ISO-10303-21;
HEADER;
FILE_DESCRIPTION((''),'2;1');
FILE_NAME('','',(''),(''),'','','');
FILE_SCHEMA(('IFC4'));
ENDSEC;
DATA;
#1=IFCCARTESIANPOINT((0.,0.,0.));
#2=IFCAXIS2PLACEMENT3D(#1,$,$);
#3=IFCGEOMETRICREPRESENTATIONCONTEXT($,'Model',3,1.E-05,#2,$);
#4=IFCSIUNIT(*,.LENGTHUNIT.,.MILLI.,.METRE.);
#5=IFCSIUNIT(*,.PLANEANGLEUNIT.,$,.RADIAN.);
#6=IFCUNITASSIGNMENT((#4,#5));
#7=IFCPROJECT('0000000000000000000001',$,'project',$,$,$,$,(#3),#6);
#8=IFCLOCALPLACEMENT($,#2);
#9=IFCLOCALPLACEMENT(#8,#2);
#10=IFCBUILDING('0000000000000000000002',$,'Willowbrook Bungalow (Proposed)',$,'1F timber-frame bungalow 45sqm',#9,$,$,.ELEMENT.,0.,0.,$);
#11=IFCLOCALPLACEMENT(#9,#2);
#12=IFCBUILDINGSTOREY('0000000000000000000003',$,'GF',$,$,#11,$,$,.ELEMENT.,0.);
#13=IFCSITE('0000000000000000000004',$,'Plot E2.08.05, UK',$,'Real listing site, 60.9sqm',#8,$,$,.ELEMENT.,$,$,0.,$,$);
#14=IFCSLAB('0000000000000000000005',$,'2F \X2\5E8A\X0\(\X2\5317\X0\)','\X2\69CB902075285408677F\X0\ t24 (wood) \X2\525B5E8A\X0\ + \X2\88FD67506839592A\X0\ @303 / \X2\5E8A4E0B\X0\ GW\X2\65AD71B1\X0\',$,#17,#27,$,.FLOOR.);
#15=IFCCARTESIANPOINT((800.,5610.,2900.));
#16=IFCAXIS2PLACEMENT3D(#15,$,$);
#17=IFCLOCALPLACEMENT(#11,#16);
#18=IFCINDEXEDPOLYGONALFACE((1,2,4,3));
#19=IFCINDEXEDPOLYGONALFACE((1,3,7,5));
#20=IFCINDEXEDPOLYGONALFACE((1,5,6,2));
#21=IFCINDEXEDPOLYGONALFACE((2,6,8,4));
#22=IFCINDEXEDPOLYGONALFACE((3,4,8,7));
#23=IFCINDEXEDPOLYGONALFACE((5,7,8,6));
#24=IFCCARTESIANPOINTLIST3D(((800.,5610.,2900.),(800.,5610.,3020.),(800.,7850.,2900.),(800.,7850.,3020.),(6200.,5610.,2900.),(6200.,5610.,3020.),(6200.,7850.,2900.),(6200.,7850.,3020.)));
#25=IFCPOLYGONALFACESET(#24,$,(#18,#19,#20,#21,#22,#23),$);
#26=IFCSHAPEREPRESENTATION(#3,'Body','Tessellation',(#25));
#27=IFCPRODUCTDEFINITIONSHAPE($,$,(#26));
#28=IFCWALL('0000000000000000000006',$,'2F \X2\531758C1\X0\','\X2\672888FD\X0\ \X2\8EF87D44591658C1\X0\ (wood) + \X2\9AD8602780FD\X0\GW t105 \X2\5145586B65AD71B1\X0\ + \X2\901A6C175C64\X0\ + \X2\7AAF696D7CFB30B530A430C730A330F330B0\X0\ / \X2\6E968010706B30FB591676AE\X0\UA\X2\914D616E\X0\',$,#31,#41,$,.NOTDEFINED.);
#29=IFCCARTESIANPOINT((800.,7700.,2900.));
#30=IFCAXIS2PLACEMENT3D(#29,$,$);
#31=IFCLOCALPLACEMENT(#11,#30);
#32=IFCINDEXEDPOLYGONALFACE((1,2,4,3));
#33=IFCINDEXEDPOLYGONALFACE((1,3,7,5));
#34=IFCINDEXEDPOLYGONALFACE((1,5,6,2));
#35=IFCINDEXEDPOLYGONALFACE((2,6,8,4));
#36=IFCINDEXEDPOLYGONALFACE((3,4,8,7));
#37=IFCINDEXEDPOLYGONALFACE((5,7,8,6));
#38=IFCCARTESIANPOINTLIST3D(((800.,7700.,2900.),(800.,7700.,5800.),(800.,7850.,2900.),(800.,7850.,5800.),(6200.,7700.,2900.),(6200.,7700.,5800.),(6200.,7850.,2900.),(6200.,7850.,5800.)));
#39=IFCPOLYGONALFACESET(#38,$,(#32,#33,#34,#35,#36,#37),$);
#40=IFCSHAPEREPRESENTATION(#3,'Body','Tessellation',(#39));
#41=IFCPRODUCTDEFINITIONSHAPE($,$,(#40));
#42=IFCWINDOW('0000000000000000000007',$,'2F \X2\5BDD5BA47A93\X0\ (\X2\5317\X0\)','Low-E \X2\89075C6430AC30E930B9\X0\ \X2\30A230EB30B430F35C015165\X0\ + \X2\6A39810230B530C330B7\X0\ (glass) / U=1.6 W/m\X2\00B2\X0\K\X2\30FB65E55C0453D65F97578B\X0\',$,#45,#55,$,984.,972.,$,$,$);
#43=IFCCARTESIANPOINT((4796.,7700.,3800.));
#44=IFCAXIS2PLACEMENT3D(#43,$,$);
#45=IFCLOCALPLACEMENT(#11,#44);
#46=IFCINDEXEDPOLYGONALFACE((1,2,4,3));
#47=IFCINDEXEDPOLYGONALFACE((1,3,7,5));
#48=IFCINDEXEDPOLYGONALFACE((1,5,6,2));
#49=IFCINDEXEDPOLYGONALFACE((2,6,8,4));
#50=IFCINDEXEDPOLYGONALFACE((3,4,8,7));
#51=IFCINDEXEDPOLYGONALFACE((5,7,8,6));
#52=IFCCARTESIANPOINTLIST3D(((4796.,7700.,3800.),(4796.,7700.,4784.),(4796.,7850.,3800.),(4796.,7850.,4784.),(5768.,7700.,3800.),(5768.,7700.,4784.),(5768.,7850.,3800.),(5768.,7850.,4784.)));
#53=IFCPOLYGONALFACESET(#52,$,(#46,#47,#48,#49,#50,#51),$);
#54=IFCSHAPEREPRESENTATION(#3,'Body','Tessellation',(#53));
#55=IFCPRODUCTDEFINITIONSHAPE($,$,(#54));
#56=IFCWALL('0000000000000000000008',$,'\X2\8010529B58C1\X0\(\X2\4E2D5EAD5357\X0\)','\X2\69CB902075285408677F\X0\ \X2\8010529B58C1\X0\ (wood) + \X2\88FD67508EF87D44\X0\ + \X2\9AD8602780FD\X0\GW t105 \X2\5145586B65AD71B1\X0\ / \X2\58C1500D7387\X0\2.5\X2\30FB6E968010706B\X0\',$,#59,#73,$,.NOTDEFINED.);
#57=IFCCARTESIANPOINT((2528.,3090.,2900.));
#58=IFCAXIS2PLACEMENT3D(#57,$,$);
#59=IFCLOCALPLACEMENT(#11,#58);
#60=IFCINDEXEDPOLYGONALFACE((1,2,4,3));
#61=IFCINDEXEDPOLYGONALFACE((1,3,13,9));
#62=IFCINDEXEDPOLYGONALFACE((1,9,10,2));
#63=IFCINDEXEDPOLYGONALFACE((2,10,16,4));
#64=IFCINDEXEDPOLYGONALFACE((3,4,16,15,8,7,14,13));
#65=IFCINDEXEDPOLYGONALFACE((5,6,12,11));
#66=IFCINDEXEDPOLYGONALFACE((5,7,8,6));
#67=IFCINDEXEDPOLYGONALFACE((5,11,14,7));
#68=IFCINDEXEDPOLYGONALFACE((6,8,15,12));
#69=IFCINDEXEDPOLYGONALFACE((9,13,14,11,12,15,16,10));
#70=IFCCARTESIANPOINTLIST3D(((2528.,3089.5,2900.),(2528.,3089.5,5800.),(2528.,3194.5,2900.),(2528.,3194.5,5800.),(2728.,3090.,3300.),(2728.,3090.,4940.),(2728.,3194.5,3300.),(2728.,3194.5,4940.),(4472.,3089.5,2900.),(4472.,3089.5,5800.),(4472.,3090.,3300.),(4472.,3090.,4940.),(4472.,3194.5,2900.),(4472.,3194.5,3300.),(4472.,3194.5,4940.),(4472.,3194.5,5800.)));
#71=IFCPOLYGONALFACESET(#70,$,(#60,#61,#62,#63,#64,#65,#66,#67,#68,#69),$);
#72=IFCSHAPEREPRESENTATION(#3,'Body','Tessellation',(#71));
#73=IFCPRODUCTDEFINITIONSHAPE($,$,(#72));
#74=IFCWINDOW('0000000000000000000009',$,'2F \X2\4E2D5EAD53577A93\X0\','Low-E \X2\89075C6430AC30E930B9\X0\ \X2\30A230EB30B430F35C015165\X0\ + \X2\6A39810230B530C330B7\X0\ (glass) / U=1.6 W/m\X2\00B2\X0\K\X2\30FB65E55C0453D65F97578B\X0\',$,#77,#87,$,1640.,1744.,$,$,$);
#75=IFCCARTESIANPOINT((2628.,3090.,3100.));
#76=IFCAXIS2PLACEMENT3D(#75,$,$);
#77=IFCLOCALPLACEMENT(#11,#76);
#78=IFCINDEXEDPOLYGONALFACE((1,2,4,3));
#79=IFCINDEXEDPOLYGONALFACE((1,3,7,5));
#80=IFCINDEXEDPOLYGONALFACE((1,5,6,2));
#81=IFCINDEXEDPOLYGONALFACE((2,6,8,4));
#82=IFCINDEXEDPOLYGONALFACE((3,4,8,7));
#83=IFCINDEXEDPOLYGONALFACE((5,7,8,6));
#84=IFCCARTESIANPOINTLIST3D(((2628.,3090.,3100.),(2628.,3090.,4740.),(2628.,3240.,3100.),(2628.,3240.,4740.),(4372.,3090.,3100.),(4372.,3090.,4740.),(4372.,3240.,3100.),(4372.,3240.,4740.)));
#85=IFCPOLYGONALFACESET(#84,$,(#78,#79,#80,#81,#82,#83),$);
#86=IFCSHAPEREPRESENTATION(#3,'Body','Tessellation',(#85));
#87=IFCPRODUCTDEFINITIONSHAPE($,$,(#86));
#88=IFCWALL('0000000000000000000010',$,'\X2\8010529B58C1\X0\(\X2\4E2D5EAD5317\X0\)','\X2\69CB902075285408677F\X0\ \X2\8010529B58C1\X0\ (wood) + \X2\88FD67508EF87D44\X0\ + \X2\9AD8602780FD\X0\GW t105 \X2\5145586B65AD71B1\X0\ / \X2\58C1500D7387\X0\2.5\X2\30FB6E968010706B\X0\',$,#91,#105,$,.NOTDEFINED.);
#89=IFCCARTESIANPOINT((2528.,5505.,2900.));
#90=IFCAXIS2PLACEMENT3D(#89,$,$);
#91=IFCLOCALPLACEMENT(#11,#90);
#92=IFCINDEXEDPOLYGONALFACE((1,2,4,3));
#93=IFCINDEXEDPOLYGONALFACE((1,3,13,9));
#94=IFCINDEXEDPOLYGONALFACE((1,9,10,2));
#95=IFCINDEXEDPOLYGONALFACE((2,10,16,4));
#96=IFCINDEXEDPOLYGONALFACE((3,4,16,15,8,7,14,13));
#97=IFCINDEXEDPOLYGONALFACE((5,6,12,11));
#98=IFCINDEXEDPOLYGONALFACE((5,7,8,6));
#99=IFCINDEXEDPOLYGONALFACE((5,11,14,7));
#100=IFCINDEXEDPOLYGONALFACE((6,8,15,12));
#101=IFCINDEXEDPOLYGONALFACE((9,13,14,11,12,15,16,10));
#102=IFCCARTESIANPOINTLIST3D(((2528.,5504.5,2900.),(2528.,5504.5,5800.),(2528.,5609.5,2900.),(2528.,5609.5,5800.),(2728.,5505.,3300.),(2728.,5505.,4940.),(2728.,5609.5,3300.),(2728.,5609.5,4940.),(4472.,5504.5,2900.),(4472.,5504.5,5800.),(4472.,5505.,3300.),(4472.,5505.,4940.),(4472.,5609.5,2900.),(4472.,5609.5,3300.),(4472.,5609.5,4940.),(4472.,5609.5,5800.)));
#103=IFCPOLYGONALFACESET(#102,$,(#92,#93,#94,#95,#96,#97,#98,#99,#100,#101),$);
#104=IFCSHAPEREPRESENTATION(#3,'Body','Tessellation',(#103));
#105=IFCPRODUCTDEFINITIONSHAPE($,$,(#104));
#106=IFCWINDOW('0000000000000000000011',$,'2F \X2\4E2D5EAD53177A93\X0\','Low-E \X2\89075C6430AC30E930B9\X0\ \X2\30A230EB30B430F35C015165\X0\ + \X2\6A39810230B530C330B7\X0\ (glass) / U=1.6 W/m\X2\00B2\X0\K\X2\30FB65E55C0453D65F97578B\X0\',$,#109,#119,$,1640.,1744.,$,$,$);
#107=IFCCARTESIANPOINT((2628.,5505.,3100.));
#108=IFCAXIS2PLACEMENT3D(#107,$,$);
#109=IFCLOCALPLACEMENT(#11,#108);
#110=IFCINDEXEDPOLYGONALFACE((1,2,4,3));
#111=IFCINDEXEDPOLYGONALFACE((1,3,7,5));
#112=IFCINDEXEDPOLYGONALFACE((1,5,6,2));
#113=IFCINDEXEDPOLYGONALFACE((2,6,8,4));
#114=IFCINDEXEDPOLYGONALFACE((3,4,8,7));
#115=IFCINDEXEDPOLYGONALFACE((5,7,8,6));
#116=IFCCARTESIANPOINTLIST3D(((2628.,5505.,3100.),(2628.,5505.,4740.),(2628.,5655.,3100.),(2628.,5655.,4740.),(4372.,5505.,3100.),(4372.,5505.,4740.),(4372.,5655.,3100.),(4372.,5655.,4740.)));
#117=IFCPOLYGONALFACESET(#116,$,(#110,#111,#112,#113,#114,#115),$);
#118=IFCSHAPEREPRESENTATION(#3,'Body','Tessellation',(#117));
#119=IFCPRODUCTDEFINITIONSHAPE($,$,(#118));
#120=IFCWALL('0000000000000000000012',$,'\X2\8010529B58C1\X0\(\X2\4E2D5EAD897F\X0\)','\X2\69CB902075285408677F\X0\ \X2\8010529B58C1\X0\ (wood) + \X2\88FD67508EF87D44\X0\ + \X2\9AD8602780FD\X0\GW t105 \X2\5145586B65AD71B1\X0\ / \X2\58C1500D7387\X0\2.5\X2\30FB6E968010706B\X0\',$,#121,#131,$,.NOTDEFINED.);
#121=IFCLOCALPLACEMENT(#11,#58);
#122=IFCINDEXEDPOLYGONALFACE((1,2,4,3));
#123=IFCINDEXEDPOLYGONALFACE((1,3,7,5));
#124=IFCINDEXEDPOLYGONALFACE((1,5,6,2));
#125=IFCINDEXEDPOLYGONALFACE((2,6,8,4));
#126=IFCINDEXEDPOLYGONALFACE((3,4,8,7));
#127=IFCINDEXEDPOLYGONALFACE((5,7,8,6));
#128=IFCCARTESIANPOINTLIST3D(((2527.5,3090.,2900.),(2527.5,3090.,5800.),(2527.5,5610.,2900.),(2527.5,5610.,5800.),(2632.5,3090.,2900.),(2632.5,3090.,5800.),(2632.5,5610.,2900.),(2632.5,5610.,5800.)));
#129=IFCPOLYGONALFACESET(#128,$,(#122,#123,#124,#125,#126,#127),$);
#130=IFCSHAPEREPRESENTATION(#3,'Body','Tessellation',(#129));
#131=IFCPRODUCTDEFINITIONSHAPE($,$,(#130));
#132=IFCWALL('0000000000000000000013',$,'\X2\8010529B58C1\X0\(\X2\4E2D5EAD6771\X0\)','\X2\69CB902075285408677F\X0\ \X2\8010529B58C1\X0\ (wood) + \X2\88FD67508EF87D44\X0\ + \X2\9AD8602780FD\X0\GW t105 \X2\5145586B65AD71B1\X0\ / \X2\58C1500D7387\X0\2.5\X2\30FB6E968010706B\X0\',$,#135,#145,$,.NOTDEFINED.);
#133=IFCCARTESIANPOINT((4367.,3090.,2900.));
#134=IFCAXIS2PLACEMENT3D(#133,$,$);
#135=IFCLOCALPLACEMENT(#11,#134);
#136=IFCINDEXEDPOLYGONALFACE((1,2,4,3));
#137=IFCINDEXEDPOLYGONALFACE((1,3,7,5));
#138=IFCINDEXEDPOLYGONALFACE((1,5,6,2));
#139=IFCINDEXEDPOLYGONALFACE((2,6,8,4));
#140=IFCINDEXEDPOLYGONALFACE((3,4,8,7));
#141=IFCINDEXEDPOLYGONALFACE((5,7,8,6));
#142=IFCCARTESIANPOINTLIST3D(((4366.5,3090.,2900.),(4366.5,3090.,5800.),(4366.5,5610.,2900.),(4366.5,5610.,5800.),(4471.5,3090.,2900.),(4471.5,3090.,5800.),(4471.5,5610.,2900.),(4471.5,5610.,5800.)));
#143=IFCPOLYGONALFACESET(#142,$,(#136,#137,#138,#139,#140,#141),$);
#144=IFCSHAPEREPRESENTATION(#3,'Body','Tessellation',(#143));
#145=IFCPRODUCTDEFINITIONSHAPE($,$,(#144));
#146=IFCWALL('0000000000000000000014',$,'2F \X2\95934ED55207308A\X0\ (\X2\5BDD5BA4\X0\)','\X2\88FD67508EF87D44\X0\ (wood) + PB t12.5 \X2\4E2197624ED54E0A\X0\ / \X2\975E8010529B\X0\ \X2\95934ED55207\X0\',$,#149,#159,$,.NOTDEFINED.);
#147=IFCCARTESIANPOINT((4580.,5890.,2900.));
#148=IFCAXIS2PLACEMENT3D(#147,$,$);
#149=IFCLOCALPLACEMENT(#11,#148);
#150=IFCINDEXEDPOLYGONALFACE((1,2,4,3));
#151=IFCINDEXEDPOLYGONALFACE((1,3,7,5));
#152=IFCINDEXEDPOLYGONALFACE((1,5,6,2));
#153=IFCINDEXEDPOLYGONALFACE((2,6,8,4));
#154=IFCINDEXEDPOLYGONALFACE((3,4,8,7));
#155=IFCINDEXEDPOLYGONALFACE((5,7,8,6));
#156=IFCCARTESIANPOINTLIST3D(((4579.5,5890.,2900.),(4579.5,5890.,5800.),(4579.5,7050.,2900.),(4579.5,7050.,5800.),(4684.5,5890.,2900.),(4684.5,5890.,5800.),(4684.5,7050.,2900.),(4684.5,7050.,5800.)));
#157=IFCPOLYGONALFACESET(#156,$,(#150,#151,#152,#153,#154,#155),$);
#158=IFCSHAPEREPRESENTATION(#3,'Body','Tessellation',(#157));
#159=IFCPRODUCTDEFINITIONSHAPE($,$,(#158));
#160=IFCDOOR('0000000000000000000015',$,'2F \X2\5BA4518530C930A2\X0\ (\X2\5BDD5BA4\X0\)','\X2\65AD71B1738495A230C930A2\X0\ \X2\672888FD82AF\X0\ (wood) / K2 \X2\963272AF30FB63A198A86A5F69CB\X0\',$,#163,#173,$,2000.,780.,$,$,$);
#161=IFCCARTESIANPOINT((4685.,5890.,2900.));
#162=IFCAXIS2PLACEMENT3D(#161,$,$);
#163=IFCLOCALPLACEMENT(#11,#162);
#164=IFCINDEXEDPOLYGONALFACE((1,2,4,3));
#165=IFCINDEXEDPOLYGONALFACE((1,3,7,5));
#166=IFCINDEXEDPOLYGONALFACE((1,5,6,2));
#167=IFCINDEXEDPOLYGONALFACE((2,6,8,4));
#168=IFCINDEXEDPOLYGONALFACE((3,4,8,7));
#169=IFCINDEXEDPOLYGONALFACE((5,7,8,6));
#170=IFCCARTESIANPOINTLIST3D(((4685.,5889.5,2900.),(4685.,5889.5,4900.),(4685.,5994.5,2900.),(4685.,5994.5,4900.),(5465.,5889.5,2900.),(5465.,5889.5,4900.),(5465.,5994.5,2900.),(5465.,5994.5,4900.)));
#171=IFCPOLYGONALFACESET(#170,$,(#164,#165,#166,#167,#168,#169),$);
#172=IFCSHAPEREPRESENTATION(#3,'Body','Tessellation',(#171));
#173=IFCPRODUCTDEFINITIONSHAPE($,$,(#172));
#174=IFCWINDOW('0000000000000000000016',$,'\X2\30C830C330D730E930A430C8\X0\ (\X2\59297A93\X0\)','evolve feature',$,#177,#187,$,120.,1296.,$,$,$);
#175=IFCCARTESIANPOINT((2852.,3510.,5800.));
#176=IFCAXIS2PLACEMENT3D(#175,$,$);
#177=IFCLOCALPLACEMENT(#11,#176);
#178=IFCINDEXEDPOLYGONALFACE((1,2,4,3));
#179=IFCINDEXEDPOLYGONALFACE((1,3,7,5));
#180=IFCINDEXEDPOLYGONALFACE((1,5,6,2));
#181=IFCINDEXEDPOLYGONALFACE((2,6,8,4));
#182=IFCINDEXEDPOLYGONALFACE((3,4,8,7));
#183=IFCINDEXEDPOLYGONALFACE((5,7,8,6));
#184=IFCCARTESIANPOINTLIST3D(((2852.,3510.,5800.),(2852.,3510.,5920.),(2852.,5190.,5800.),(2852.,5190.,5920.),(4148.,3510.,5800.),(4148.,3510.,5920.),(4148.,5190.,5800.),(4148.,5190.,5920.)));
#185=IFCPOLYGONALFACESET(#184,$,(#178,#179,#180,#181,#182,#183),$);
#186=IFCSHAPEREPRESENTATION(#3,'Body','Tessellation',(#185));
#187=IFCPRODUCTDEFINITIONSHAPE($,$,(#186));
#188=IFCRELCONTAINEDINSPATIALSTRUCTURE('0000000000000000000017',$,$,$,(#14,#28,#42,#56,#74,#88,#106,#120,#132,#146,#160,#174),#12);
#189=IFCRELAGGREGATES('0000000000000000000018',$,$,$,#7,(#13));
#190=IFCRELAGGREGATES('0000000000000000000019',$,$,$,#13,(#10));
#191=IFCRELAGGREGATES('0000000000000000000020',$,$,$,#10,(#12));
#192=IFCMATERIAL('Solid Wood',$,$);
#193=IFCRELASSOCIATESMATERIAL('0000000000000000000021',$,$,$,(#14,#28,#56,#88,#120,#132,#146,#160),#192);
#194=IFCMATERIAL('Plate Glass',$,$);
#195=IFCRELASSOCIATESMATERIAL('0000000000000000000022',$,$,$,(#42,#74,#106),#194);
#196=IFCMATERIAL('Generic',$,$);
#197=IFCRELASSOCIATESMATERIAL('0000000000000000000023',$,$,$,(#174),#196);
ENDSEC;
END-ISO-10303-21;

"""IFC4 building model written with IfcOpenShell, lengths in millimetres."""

from ifc_helpers import new_model, si_unit, frame, frame_2d, origin, place, context, project, spatial, rectangle, extrude, material, element, fill, save


model = new_model("IFC4")

# Units and contexts
model_context = context("Model", 3, precision=1e-05, world=origin())
ifc_project = project(units=[si_unit("LENGTHUNIT", "METRE", prefix="MILLI"), si_unit("PLANEANGLEUNIT", "RADIAN")], contexts=[model_context])

# Site, building, storey
site_placement = place(None, origin())
site = spatial("IfcSite", under=ifc_project, at=site_placement, Name="Plot E2.08.05, UK", ObjectType="Real listing site, 60.9sqm", CompositionType="ELEMENT", RefElevation=0.0)
building_placement = place(site_placement, origin())
building = spatial("IfcBuilding", under=site, at=building_placement, Name="Willowbrook Bungalow (Proposed)", ObjectType="1F timber-frame bungalow 45sqm", CompositionType="ELEMENT", ElevationOfRefHeight=0.0, ElevationOfTerrain=0.0)
storey_placement = place(building_placement, origin())
storey = spatial("IfcBuildingStorey", under=building, at=storey_placement, Name="GF", CompositionType="ELEMENT", Elevation=0.0)

# Slab
ifc_material_1 = material(Name="Solid Wood")
slab_placement = place(storey_placement, frame((800.0, 5610.0, 2900.0)))
element("IfcSlab", 1, at=slab_placement, inside=storey, material=ifc_material_1, Name="2F 床(北)", Description="構造用合板 t24 (wood) 剛床 + 製材根太 @303 / 床下 GW断熱", PredefinedType="FLOOR", context=model_context, shape_type="SweptSolid", body=[
    extrude(rectangle(XDim=5400.0, YDim=2240.0, at=frame_2d((2700.0, 1120.0))), frame((800.0, 5610.0, 2900.0)), (0.0, 0.0, 1.0), 120.0),
])

# Walls, openings, windows
wall_1_placement = place(storey_placement, frame((800.0, 7700.0, 2900.0)))
wall_1 = element("IfcWall", 2, at=wall_1_placement, inside=storey, material=ifc_material_1, Name="2F 北壁", Description="木製 軸組外壁 (wood) + 高性能GW t105 充填断熱 + 通気層 + 窯業系サイディング / 準耐火・外皮UA配慮", PredefinedType="NOTDEFINED", context=model_context, shape_type="SweptSolid", body=[
    extrude(rectangle(XDim=5400.0, YDim=150.0, at=frame_2d((2700.0, 75.0))), frame((800.0, 7700.0, 2900.0)), (0.0, 0.0, 1.0), 2900.0),
])
opening_1_placement = place(storey_placement, frame((4796.0, 7700.0, 3800.0)))
opening_1 = element("IfcOpeningElement", 3, at=opening_1_placement, cuts=wall_1, PredefinedType="NOTDEFINED", context=model_context, shape_type="SweptSolid", body=[
    extrude(rectangle(XDim=972.0, YDim=150.0, at=frame_2d((486.0, 75.0))), frame((4796.0, 7700.0, 3800.0)), (0.0, 0.0, 1.0), 984.0),
])
ifc_material_2 = material(Name="Plate Glass")
window_1_placement = place(storey_placement, frame((4796.0, 7700.0, 3800.0)))
window_1 = element("IfcWindow", 4, at=window_1_placement, inside=storey, material=ifc_material_2, Name="2F 寝室窓 (北)", Description="Low-E 複層ガラス アルゴン封入 + 樹脂サッシ (glass) / U=1.6 W/m²K・日射取得型", OverallHeight=984.0, OverallWidth=972.0, context=model_context, shape_type="SweptSolid", body=[
    extrude(rectangle(XDim=972.0, YDim=150.0, at=frame_2d((486.0, 75.0))), frame((4796.0, 7700.0, 3800.0)), (0.0, 0.0, 1.0), 984.0),
])
fill(opening_1, window_1)
wall_2_placement = place(storey_placement, frame((2528.0, 3090.0, 2900.0)))
wall_2 = element("IfcWall", 5, at=wall_2_placement, inside=storey, material=ifc_material_1, Name="耐力壁(中庭南)", Description="構造用合板 耐力壁 (wood) + 製材軸組 + 高性能GW t105 充填断熱 / 壁倍率2.5・準耐火", PredefinedType="NOTDEFINED", context=model_context, shape_type="SweptSolid", body=[
    extrude(rectangle(XDim=1944.0, YDim=105.0, at=frame_2d((972.0, 52.0))), frame((2528.0, 3090.0, 2900.0)), (0.0, 0.0, 1.0), 2900.0),
])
opening_2_placement = place(storey_placement, frame((2628.0, 3090.0, 3100.0)))
opening_2 = element("IfcOpeningElement", 6, at=opening_2_placement, cuts=wall_2, PredefinedType="NOTDEFINED", context=model_context, shape_type="SweptSolid", body=[
    extrude(rectangle(XDim=1744.0, YDim=150.0, at=frame_2d((872.0, 75.0))), frame((2628.0, 3090.0, 3100.0)), (0.0, 0.0, 1.0), 1640.0),
])
window_2_placement = place(storey_placement, frame((2628.0, 3090.0, 3100.0)))
window_2 = element("IfcWindow", 7, at=window_2_placement, inside=storey, material=ifc_material_2, Name="2F 中庭南窓", Description="Low-E 複層ガラス アルゴン封入 + 樹脂サッシ (glass) / U=1.6 W/m²K・日射取得型", OverallHeight=1640.0, OverallWidth=1744.0, context=model_context, shape_type="SweptSolid", body=[
    extrude(rectangle(XDim=1744.0, YDim=150.0, at=frame_2d((872.0, 75.0))), frame((2628.0, 3090.0, 3100.0)), (0.0, 0.0, 1.0), 1640.0),
])
fill(opening_2, window_2)
wall_3_placement = place(storey_placement, frame((2528.0, 5505.0, 2900.0)))
wall_3 = element("IfcWall", 8, at=wall_3_placement, inside=storey, material=ifc_material_1, Name="耐力壁(中庭北)", Description="構造用合板 耐力壁 (wood) + 製材軸組 + 高性能GW t105 充填断熱 / 壁倍率2.5・準耐火", PredefinedType="NOTDEFINED", context=model_context, shape_type="SweptSolid", body=[
    extrude(rectangle(XDim=1944.0, YDim=105.0, at=frame_2d((972.0, 52.0))), frame((2528.0, 5505.0, 2900.0)), (0.0, 0.0, 1.0), 2900.0),
])
opening_3_placement = place(storey_placement, frame((2628.0, 5505.0, 3100.0)))
opening_3 = element("IfcOpeningElement", 9, at=opening_3_placement, cuts=wall_3, PredefinedType="NOTDEFINED", context=model_context, shape_type="SweptSolid", body=[
    extrude(rectangle(XDim=1744.0, YDim=150.0, at=frame_2d((872.0, 75.0))), frame((2628.0, 5505.0, 3100.0)), (0.0, 0.0, 1.0), 1640.0),
])
window_3_placement = place(storey_placement, frame((2628.0, 5505.0, 3100.0)))
window_3 = element("IfcWindow", 10, at=window_3_placement, inside=storey, material=ifc_material_2, Name="2F 中庭北窓", Description="Low-E 複層ガラス アルゴン封入 + 樹脂サッシ (glass) / U=1.6 W/m²K・日射取得型", OverallHeight=1640.0, OverallWidth=1744.0, context=model_context, shape_type="SweptSolid", body=[
    extrude(rectangle(XDim=1744.0, YDim=150.0, at=frame_2d((872.0, 75.0))), frame((2628.0, 5505.0, 3100.0)), (0.0, 0.0, 1.0), 1640.0),
])
fill(opening_3, window_3)

# Walls
wall_4_placement = place(storey_placement, frame((2528.0, 3090.0, 2900.0)))
element("IfcWall", 11, at=wall_4_placement, inside=storey, material=ifc_material_1, Name="耐力壁(中庭西)", Description="構造用合板 耐力壁 (wood) + 製材軸組 + 高性能GW t105 充填断熱 / 壁倍率2.5・準耐火", PredefinedType="NOTDEFINED", context=model_context, shape_type="SweptSolid", body=[
    extrude(rectangle(XDim=105.0, YDim=2520.0, at=frame_2d((52.0, 1260.0))), frame((2528.0, 3090.0, 2900.0)), (0.0, 0.0, 1.0), 2900.0),
])
wall_5_placement = place(storey_placement, frame((4367.0, 3090.0, 2900.0)))
element("IfcWall", 12, at=wall_5_placement, inside=storey, material=ifc_material_1, Name="耐力壁(中庭東)", Description="構造用合板 耐力壁 (wood) + 製材軸組 + 高性能GW t105 充填断熱 / 壁倍率2.5・準耐火", PredefinedType="NOTDEFINED", context=model_context, shape_type="SweptSolid", body=[
    extrude(rectangle(XDim=105.0, YDim=2520.0, at=frame_2d((52.0, 1260.0))), frame((4367.0, 3090.0, 2900.0)), (0.0, 0.0, 1.0), 2900.0),
])
wall_6_placement = place(storey_placement, frame((4580.0, 5890.0, 2900.0)))
element("IfcWall", 13, at=wall_6_placement, inside=storey, material=ifc_material_1, Name="2F 間仕切り (寝室)", Description="製材軸組 (wood) + PB t12.5 両面仕上 / 非耐力 間仕切", PredefinedType="NOTDEFINED", context=model_context, shape_type="SweptSolid", body=[
    extrude(rectangle(XDim=105.0, YDim=1160.0, at=frame_2d((52.0, 580.0))), frame((4580.0, 5890.0, 2900.0)), (0.0, 0.0, 1.0), 2900.0),
])

# Door
door_placement = place(storey_placement, frame((4685.0, 5890.0, 2900.0)))
element("IfcDoor", 14, at=door_placement, inside=storey, material=ifc_material_1, Name="2F 室内ドア (寝室)", Description="断熱玄関ドア 木製芯 (wood) / K2 防犯・採風機構", OverallHeight=2000.0, OverallWidth=780.0, context=model_context, shape_type="SweptSolid", body=[
    extrude(rectangle(XDim=780.0, YDim=105.0, at=frame_2d((390.0, 52.0))), frame((4685.0, 5890.0, 2900.0)), (0.0, 0.0, 1.0), 2000.0),
])

# Window
ifc_material_3 = material(Name="Generic")
window_4_placement = place(storey_placement, frame((2852.0, 3510.0, 5800.0)))
element("IfcWindow", 15, at=window_4_placement, inside=storey, material=ifc_material_3, Name="トップライト (天窓)", Description="evolve feature", OverallHeight=120.0, OverallWidth=1296.0, context=model_context, shape_type="SweptSolid", body=[
    extrude(rectangle(XDim=1296.0, YDim=1680.0, at=frame_2d((648.0, 840.0))), frame((2852.0, 3510.0, 5800.0)), (0.0, 0.0, 1.0), 120.0),
])

save(model, "model.ifc")
